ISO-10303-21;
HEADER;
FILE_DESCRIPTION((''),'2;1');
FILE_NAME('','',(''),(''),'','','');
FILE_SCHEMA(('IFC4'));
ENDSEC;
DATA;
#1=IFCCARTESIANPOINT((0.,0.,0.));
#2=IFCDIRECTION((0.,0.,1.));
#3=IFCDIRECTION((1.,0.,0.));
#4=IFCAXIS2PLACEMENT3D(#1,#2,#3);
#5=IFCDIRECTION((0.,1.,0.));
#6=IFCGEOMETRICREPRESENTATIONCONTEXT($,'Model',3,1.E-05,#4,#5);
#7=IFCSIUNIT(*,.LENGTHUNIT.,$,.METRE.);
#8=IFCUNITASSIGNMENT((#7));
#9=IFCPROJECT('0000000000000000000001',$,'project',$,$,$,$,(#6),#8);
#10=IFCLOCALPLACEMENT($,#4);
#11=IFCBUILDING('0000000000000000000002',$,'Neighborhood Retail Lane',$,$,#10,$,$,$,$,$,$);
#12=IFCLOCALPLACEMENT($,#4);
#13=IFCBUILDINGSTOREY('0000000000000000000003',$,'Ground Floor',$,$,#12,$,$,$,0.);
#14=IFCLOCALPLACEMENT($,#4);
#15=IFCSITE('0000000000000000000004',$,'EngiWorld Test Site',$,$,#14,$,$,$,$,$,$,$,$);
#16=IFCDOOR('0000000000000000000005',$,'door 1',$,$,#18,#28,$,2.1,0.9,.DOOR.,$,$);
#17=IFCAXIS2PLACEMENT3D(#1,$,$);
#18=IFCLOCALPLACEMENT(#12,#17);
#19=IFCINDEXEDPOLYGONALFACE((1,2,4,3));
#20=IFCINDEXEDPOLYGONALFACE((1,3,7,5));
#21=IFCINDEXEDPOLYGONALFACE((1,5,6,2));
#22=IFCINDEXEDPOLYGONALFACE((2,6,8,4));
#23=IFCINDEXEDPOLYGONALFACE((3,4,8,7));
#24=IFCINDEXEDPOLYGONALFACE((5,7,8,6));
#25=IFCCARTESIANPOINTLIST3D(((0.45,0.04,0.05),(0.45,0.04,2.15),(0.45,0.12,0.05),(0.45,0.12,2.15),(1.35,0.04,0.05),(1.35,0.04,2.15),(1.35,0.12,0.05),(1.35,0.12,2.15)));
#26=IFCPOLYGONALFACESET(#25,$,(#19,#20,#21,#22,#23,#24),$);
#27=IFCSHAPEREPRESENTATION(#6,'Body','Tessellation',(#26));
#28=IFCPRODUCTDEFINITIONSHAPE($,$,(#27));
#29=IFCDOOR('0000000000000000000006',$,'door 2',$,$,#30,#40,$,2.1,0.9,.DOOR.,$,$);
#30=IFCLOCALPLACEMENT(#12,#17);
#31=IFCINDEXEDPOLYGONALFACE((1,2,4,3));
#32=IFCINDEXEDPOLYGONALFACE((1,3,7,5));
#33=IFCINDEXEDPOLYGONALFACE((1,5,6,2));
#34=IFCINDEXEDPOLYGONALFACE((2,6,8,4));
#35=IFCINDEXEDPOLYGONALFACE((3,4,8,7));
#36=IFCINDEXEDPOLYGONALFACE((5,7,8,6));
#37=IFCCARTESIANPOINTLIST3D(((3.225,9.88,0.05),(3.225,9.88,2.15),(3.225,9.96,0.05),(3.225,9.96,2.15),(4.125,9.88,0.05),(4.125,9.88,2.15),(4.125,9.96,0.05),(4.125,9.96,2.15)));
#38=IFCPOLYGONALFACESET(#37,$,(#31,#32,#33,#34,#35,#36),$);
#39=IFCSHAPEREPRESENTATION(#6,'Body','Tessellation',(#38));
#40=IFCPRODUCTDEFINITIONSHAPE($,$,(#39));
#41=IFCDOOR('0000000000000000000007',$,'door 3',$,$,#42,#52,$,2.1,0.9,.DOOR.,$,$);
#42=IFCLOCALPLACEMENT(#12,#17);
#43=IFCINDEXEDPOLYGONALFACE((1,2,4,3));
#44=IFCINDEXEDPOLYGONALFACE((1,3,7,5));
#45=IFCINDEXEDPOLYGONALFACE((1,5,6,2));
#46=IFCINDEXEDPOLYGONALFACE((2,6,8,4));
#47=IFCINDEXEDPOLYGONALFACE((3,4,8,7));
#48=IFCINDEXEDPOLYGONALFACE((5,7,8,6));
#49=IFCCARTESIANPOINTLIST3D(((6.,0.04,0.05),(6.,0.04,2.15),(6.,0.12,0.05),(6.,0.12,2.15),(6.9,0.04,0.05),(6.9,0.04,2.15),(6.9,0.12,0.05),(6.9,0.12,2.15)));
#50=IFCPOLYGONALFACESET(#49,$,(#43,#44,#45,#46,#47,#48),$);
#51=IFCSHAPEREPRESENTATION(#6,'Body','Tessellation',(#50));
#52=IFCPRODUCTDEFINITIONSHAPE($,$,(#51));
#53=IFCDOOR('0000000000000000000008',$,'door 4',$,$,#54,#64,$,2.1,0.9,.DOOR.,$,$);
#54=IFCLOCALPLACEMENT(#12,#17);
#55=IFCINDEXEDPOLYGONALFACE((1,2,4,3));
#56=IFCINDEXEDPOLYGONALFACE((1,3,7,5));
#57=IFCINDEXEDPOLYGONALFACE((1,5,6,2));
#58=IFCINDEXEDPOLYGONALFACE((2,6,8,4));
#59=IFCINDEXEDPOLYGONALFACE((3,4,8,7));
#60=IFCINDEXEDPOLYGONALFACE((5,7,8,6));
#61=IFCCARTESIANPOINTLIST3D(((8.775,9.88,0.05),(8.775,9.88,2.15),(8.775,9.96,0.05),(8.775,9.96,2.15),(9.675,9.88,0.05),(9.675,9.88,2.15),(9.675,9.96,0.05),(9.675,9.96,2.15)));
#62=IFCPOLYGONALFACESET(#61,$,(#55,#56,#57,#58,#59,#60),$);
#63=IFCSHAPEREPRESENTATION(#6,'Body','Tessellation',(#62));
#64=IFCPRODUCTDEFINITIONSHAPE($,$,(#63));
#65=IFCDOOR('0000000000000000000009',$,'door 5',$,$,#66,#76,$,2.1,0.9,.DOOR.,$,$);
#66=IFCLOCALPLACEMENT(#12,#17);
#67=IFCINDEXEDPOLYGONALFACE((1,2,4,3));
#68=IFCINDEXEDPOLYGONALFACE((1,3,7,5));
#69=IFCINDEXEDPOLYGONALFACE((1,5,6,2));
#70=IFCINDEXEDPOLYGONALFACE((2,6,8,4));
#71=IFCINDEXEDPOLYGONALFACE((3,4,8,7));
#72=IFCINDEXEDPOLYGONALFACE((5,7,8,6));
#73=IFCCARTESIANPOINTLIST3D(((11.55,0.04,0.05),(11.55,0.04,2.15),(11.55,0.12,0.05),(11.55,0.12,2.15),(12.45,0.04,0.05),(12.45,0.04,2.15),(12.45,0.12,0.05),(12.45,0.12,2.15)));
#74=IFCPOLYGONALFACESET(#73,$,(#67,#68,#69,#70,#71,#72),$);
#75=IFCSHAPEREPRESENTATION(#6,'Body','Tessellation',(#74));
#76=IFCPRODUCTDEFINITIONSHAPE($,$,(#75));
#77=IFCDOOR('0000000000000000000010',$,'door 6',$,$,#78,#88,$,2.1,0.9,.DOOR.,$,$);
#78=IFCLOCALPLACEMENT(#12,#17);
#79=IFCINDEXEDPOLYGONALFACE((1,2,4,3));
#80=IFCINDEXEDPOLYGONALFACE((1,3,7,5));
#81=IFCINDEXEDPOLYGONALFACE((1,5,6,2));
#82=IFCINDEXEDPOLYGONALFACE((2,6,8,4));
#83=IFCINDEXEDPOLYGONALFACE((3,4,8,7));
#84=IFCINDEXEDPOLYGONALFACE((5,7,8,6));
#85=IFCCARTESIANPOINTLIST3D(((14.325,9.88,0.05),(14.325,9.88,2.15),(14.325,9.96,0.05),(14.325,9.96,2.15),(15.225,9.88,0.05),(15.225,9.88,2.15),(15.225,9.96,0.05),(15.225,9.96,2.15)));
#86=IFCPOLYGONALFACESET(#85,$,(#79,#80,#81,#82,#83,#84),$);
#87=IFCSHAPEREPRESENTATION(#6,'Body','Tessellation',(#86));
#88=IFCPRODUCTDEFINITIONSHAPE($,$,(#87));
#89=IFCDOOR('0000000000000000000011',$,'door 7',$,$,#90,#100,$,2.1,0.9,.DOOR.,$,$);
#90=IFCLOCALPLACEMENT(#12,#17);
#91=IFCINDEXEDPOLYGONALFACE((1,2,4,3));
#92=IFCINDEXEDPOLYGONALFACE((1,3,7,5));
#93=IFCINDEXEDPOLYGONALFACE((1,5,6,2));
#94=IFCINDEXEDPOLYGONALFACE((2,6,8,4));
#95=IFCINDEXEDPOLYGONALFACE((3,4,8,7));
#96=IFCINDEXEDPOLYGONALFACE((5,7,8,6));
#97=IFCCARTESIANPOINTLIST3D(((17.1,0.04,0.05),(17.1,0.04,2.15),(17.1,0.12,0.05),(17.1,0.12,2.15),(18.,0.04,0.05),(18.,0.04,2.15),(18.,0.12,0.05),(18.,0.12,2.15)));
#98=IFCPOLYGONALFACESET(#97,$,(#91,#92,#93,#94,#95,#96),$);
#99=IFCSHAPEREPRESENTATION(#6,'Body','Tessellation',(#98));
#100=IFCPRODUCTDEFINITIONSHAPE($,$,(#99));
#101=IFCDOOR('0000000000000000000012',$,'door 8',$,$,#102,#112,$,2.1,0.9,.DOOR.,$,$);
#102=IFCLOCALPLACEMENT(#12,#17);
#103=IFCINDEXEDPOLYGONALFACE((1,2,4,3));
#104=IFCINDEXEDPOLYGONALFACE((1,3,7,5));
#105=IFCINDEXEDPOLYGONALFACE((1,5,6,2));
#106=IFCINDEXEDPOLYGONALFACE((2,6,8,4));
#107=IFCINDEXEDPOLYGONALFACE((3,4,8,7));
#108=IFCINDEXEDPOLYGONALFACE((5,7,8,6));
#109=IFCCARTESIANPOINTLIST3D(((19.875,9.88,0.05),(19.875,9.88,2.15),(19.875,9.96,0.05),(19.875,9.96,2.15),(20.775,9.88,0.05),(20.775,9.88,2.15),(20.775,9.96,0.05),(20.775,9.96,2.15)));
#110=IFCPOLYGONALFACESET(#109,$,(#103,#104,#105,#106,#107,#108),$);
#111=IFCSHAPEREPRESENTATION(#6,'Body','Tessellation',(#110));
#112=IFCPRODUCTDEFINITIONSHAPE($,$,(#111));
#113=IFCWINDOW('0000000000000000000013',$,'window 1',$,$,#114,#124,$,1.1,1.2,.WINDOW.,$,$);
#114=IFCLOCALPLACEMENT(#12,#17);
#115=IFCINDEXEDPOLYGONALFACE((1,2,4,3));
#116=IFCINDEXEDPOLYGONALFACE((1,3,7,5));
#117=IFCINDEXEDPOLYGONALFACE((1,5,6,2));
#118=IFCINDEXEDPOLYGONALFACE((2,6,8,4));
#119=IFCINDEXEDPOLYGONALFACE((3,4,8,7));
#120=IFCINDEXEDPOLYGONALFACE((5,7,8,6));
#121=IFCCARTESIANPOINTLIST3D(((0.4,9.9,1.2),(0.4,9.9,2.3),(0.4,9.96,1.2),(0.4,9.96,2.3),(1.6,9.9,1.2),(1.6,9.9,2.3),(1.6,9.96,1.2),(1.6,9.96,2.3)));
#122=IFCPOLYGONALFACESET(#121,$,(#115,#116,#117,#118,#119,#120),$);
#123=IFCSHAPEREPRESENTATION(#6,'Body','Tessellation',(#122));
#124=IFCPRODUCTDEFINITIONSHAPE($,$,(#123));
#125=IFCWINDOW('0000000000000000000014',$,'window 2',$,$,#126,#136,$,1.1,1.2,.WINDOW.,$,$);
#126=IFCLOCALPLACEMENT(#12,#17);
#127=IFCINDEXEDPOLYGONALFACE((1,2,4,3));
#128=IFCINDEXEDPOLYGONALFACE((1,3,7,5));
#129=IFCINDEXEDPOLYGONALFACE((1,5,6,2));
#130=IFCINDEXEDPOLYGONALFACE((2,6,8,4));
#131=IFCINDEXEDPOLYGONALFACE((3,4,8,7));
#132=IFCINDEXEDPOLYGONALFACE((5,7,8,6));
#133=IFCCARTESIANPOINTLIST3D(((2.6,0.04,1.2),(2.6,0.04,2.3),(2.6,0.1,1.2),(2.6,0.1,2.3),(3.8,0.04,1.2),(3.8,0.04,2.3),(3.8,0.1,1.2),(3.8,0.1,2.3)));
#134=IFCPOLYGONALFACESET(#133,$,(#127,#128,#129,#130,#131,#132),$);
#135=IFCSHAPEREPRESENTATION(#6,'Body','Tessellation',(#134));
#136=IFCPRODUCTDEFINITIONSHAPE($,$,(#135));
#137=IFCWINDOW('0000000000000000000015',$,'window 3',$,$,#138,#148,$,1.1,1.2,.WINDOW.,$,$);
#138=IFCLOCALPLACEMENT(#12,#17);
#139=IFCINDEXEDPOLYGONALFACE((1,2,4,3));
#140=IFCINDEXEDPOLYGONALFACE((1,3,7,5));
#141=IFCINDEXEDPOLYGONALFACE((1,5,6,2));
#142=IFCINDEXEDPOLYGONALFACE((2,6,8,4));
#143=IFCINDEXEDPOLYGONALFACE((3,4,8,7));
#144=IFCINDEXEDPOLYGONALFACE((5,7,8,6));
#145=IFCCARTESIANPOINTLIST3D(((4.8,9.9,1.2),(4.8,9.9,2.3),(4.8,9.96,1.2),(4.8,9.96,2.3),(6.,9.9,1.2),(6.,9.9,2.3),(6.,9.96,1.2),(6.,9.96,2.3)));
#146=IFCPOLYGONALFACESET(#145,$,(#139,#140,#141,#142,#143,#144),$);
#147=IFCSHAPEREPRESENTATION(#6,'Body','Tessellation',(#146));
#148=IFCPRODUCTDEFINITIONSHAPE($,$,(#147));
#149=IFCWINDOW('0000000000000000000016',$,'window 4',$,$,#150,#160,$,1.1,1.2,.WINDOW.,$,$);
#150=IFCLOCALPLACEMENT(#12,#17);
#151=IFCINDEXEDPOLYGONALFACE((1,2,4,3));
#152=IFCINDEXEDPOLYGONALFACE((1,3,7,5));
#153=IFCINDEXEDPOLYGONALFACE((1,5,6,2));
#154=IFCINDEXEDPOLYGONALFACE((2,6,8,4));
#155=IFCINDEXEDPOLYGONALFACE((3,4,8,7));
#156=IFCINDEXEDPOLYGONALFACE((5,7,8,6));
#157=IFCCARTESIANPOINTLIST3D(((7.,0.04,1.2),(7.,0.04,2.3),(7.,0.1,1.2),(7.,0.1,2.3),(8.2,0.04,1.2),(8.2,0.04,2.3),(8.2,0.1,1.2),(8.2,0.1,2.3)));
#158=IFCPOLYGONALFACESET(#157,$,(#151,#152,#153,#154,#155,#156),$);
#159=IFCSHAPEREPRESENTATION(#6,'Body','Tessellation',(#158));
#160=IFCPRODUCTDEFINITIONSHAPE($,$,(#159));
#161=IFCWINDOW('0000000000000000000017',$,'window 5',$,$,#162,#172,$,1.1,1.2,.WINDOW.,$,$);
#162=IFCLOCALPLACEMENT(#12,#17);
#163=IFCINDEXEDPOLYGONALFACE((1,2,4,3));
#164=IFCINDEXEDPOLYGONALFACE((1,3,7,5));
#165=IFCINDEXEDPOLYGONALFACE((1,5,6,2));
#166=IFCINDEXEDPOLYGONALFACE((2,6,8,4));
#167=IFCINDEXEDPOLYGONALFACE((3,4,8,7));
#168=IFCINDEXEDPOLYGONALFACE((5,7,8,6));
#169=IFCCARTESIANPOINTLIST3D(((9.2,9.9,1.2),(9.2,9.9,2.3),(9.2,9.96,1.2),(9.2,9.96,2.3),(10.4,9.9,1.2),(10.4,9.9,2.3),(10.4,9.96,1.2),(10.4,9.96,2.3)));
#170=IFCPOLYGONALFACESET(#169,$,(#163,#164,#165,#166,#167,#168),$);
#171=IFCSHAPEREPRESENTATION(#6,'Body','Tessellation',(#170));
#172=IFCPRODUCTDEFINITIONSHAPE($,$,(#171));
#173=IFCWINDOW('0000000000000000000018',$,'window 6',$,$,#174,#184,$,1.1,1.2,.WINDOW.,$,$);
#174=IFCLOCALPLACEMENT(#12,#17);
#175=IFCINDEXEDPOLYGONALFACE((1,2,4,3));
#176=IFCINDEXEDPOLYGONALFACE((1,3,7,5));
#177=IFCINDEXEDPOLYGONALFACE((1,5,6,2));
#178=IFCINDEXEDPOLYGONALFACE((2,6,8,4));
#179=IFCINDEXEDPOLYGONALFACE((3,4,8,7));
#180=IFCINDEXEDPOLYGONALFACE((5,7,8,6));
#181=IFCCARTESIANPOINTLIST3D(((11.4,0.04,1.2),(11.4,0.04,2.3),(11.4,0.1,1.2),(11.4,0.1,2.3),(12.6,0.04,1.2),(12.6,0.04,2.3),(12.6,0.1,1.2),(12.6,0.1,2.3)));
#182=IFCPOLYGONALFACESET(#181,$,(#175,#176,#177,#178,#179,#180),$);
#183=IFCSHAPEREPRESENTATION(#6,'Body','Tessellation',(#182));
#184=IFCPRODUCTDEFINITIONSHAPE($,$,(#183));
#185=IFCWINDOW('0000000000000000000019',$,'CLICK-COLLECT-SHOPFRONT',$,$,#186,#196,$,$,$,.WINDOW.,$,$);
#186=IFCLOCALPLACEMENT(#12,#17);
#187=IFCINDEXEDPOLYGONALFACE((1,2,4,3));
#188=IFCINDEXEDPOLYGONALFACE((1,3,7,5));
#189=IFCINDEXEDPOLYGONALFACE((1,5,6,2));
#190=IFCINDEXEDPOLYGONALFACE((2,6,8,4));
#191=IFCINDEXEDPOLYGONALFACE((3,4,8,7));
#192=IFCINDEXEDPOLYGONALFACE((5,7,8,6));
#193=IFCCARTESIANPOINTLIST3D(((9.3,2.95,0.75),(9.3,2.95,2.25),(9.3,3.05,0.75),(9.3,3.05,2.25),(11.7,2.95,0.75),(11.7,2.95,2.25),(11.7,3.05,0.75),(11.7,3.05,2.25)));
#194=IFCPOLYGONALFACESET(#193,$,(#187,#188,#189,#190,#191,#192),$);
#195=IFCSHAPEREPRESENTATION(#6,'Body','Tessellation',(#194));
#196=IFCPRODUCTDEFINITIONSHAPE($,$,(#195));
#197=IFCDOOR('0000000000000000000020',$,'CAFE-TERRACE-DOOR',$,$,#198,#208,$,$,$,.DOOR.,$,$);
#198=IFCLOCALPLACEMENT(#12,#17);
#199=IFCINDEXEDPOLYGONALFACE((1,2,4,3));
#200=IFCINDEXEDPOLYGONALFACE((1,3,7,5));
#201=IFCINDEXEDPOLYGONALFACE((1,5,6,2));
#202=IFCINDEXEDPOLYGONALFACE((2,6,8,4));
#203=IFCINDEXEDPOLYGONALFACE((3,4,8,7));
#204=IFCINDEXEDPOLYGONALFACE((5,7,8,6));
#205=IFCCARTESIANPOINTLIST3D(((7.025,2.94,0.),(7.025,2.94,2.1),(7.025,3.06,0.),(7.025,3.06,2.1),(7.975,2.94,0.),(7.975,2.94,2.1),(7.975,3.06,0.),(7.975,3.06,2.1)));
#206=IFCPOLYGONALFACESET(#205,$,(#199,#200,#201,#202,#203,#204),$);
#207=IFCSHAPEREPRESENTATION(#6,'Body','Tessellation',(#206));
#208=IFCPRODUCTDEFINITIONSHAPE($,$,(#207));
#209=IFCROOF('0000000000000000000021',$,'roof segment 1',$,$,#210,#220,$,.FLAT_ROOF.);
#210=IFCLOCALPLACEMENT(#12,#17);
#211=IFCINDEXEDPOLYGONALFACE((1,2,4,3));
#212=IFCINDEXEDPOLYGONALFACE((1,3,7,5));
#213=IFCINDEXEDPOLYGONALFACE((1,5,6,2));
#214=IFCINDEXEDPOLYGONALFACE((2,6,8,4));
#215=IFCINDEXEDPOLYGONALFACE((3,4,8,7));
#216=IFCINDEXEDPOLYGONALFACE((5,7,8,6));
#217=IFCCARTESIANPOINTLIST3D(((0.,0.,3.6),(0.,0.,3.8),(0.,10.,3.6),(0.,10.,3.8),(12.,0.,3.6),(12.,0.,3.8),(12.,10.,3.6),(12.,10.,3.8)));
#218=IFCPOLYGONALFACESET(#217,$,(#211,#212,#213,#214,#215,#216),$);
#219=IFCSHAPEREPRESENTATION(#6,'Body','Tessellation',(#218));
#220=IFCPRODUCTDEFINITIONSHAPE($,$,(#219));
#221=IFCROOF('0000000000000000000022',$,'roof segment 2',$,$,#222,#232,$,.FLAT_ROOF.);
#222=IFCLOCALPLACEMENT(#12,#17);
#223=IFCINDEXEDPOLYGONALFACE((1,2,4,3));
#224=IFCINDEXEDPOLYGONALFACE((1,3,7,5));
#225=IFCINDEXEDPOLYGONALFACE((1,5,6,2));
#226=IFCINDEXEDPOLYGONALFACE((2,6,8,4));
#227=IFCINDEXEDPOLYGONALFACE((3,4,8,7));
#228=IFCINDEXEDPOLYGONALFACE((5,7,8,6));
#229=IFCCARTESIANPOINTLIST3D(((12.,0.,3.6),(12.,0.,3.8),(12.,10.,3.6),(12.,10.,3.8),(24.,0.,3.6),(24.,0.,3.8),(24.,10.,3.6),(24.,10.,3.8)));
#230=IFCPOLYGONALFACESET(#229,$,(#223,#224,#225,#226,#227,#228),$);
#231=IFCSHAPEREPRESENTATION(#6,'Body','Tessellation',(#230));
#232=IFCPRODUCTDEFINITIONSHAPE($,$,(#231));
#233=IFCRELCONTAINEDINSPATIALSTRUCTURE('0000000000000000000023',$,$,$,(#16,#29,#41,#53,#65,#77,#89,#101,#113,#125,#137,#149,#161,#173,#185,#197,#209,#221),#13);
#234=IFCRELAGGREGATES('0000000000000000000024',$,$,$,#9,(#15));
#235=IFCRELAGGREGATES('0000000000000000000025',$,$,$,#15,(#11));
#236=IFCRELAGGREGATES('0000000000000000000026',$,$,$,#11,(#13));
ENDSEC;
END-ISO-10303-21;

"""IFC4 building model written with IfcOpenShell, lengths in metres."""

from ifc_helpers import new_model, si_unit, direction, frame, origin, origin_with_axes, origin_2d, origin_2d_with_axis, place, context, project, spatial, rectangle, extrude, element, save


model = new_model("IFC4")

# Units and contexts
model_context = context("Model", 3, precision=1e-05, world=origin_with_axes(), true_north=direction((0.0, 1.0, 0.0)))
ifc_project = project(units=[si_unit("LENGTHUNIT", "METRE")], contexts=[model_context])

# Site, building, storey
site_placement = place(None, origin_with_axes())
site = spatial("IfcSite", under=ifc_project, at=site_placement, Name="EngiWorld Test Site")
building_placement = place(None, origin_with_axes())
building = spatial("IfcBuilding", under=site, at=building_placement, Name="Neighborhood Retail Lane")
storey_placement = place(None, origin_with_axes())
storey = spatial("IfcBuildingStorey", under=building, at=storey_placement, Name="Ground Floor", Elevation=0.0)

# Doors
for number, where, z_axis, x_axis, name in (
    (1, (0.9, 0.08, 0.05), (0.0, 0.0, 1.0), (1.0, 0.0, 0.0), "door 1"),
    (2, (3.675, 9.92, 0.05), (0.0, 0.0, 1.0), (1.0, 0.0, 0.0), "door 2"),
    (3, (6.45, 0.08, 0.05), (0.0, 0.0, 1.0), (1.0, 0.0, 0.0), "door 3"),
    (4, (9.225, 9.92, 0.05), (0.0, 0.0, 1.0), (1.0, 0.0, 0.0), "door 4"),
    (5, (12.0, 0.08, 0.05), (0.0, 0.0, 1.0), (1.0, 0.0, 0.0), "door 5"),
    (6, (14.775, 9.92, 0.05), (0.0, 0.0, 1.0), (1.0, 0.0, 0.0), "door 6"),
    (7, (17.55, 0.08, 0.05), (0.0, 0.0, 1.0), (1.0, 0.0, 0.0), "door 7"),
    (8, (20.325, 9.92, 0.05), (0.0, 0.0, 1.0), (1.0, 0.0, 0.0), "door 8"),
):
    element("IfcDoor", number, at=place(None, frame(where, z_axis=z_axis, x_axis=x_axis)), inside=storey, Name=name, OverallHeight=2.1, OverallWidth=0.9, PredefinedType="DOOR", context=model_context, shape_type="SweptSolid", body=[
        extrude(rectangle(XDim=0.9, YDim=0.08, at=origin_2d_with_axis()), origin_with_axes(), (0.0, 0.0, 1.0), 2.1),
    ])

# Windows
for number, where, z_axis, x_axis, name in (
    (9, (1.0, 9.93, 1.2), (0.0, 0.0, 1.0), (1.0, 0.0, 0.0), "window 1"),
    (10, (3.2, 0.07, 1.2), (0.0, 0.0, 1.0), (1.0, 0.0, 0.0), "window 2"),
    (11, (5.4, 9.93, 1.2), (0.0, 0.0, 1.0), (1.0, 0.0, 0.0), "window 3"),
    (12, (7.6, 0.07, 1.2), (0.0, 0.0, 1.0), (1.0, 0.0, 0.0), "window 4"),
    (13, (9.8, 9.93, 1.2), (0.0, 0.0, 1.0), (1.0, 0.0, 0.0), "window 5"),
    (14, (12.0, 0.07, 1.2), (0.0, 0.0, 1.0), (1.0, 0.0, 0.0), "window 6"),
):
    element("IfcWindow", number, at=place(None, frame(where, z_axis=z_axis, x_axis=x_axis)), inside=storey, Name=name, OverallHeight=1.1, OverallWidth=1.2, PredefinedType="WINDOW", context=model_context, shape_type="SweptSolid", body=[
        extrude(rectangle(XDim=1.2, YDim=0.06, at=origin_2d_with_axis()), origin_with_axes(), (0.0, 0.0, 1.0), 1.1),
    ])
window_placement = place(None, frame((10.5, 3.0, 0.75)))
element("IfcWindow", 15, at=window_placement, inside=storey, Name="CLICK-COLLECT-SHOPFRONT", PredefinedType="WINDOW", context=model_context, shape_type="SweptSolid", body=[
    extrude(rectangle(XDim=2.4, YDim=0.1, at=origin_2d()), origin(), (0.0, 0.0, 1.0), 1.5),
])

# Door
door_placement = place(None, frame((7.5, 3.0, 0.0)))
element("IfcDoor", 16, at=door_placement, inside=storey, Name="CAFE-TERRACE-DOOR", PredefinedType="DOOR", context=model_context, shape_type="SweptSolid", body=[
    extrude(rectangle(XDim=0.95, YDim=0.12, at=origin_2d()), origin(), (0.0, 0.0, 1.0), 2.1),
])

# Roofs
for number, where, z_axis, x_axis, name in (
    (17, (6.0, 5.0, 3.6), (0.0, 0.0, 1.0), (1.0, 0.0, 0.0), "roof segment 1"),
    (18, (18.0, 5.0, 3.6), (0.0, 0.0, 1.0), (1.0, 0.0, 0.0), "roof segment 2"),
):
    element("IfcRoof", number, at=place(None, frame(where, z_axis=z_axis, x_axis=x_axis)), inside=storey, Name=name, PredefinedType="FLAT_ROOF", context=model_context, shape_type="SweptSolid", body=[
        extrude(rectangle(XDim=12.0, YDim=10.0, at=origin_2d_with_axis()), origin_with_axes(), (0.0, 0.0, 1.0), 0.2),
    ])

save(model, "model.ifc")
